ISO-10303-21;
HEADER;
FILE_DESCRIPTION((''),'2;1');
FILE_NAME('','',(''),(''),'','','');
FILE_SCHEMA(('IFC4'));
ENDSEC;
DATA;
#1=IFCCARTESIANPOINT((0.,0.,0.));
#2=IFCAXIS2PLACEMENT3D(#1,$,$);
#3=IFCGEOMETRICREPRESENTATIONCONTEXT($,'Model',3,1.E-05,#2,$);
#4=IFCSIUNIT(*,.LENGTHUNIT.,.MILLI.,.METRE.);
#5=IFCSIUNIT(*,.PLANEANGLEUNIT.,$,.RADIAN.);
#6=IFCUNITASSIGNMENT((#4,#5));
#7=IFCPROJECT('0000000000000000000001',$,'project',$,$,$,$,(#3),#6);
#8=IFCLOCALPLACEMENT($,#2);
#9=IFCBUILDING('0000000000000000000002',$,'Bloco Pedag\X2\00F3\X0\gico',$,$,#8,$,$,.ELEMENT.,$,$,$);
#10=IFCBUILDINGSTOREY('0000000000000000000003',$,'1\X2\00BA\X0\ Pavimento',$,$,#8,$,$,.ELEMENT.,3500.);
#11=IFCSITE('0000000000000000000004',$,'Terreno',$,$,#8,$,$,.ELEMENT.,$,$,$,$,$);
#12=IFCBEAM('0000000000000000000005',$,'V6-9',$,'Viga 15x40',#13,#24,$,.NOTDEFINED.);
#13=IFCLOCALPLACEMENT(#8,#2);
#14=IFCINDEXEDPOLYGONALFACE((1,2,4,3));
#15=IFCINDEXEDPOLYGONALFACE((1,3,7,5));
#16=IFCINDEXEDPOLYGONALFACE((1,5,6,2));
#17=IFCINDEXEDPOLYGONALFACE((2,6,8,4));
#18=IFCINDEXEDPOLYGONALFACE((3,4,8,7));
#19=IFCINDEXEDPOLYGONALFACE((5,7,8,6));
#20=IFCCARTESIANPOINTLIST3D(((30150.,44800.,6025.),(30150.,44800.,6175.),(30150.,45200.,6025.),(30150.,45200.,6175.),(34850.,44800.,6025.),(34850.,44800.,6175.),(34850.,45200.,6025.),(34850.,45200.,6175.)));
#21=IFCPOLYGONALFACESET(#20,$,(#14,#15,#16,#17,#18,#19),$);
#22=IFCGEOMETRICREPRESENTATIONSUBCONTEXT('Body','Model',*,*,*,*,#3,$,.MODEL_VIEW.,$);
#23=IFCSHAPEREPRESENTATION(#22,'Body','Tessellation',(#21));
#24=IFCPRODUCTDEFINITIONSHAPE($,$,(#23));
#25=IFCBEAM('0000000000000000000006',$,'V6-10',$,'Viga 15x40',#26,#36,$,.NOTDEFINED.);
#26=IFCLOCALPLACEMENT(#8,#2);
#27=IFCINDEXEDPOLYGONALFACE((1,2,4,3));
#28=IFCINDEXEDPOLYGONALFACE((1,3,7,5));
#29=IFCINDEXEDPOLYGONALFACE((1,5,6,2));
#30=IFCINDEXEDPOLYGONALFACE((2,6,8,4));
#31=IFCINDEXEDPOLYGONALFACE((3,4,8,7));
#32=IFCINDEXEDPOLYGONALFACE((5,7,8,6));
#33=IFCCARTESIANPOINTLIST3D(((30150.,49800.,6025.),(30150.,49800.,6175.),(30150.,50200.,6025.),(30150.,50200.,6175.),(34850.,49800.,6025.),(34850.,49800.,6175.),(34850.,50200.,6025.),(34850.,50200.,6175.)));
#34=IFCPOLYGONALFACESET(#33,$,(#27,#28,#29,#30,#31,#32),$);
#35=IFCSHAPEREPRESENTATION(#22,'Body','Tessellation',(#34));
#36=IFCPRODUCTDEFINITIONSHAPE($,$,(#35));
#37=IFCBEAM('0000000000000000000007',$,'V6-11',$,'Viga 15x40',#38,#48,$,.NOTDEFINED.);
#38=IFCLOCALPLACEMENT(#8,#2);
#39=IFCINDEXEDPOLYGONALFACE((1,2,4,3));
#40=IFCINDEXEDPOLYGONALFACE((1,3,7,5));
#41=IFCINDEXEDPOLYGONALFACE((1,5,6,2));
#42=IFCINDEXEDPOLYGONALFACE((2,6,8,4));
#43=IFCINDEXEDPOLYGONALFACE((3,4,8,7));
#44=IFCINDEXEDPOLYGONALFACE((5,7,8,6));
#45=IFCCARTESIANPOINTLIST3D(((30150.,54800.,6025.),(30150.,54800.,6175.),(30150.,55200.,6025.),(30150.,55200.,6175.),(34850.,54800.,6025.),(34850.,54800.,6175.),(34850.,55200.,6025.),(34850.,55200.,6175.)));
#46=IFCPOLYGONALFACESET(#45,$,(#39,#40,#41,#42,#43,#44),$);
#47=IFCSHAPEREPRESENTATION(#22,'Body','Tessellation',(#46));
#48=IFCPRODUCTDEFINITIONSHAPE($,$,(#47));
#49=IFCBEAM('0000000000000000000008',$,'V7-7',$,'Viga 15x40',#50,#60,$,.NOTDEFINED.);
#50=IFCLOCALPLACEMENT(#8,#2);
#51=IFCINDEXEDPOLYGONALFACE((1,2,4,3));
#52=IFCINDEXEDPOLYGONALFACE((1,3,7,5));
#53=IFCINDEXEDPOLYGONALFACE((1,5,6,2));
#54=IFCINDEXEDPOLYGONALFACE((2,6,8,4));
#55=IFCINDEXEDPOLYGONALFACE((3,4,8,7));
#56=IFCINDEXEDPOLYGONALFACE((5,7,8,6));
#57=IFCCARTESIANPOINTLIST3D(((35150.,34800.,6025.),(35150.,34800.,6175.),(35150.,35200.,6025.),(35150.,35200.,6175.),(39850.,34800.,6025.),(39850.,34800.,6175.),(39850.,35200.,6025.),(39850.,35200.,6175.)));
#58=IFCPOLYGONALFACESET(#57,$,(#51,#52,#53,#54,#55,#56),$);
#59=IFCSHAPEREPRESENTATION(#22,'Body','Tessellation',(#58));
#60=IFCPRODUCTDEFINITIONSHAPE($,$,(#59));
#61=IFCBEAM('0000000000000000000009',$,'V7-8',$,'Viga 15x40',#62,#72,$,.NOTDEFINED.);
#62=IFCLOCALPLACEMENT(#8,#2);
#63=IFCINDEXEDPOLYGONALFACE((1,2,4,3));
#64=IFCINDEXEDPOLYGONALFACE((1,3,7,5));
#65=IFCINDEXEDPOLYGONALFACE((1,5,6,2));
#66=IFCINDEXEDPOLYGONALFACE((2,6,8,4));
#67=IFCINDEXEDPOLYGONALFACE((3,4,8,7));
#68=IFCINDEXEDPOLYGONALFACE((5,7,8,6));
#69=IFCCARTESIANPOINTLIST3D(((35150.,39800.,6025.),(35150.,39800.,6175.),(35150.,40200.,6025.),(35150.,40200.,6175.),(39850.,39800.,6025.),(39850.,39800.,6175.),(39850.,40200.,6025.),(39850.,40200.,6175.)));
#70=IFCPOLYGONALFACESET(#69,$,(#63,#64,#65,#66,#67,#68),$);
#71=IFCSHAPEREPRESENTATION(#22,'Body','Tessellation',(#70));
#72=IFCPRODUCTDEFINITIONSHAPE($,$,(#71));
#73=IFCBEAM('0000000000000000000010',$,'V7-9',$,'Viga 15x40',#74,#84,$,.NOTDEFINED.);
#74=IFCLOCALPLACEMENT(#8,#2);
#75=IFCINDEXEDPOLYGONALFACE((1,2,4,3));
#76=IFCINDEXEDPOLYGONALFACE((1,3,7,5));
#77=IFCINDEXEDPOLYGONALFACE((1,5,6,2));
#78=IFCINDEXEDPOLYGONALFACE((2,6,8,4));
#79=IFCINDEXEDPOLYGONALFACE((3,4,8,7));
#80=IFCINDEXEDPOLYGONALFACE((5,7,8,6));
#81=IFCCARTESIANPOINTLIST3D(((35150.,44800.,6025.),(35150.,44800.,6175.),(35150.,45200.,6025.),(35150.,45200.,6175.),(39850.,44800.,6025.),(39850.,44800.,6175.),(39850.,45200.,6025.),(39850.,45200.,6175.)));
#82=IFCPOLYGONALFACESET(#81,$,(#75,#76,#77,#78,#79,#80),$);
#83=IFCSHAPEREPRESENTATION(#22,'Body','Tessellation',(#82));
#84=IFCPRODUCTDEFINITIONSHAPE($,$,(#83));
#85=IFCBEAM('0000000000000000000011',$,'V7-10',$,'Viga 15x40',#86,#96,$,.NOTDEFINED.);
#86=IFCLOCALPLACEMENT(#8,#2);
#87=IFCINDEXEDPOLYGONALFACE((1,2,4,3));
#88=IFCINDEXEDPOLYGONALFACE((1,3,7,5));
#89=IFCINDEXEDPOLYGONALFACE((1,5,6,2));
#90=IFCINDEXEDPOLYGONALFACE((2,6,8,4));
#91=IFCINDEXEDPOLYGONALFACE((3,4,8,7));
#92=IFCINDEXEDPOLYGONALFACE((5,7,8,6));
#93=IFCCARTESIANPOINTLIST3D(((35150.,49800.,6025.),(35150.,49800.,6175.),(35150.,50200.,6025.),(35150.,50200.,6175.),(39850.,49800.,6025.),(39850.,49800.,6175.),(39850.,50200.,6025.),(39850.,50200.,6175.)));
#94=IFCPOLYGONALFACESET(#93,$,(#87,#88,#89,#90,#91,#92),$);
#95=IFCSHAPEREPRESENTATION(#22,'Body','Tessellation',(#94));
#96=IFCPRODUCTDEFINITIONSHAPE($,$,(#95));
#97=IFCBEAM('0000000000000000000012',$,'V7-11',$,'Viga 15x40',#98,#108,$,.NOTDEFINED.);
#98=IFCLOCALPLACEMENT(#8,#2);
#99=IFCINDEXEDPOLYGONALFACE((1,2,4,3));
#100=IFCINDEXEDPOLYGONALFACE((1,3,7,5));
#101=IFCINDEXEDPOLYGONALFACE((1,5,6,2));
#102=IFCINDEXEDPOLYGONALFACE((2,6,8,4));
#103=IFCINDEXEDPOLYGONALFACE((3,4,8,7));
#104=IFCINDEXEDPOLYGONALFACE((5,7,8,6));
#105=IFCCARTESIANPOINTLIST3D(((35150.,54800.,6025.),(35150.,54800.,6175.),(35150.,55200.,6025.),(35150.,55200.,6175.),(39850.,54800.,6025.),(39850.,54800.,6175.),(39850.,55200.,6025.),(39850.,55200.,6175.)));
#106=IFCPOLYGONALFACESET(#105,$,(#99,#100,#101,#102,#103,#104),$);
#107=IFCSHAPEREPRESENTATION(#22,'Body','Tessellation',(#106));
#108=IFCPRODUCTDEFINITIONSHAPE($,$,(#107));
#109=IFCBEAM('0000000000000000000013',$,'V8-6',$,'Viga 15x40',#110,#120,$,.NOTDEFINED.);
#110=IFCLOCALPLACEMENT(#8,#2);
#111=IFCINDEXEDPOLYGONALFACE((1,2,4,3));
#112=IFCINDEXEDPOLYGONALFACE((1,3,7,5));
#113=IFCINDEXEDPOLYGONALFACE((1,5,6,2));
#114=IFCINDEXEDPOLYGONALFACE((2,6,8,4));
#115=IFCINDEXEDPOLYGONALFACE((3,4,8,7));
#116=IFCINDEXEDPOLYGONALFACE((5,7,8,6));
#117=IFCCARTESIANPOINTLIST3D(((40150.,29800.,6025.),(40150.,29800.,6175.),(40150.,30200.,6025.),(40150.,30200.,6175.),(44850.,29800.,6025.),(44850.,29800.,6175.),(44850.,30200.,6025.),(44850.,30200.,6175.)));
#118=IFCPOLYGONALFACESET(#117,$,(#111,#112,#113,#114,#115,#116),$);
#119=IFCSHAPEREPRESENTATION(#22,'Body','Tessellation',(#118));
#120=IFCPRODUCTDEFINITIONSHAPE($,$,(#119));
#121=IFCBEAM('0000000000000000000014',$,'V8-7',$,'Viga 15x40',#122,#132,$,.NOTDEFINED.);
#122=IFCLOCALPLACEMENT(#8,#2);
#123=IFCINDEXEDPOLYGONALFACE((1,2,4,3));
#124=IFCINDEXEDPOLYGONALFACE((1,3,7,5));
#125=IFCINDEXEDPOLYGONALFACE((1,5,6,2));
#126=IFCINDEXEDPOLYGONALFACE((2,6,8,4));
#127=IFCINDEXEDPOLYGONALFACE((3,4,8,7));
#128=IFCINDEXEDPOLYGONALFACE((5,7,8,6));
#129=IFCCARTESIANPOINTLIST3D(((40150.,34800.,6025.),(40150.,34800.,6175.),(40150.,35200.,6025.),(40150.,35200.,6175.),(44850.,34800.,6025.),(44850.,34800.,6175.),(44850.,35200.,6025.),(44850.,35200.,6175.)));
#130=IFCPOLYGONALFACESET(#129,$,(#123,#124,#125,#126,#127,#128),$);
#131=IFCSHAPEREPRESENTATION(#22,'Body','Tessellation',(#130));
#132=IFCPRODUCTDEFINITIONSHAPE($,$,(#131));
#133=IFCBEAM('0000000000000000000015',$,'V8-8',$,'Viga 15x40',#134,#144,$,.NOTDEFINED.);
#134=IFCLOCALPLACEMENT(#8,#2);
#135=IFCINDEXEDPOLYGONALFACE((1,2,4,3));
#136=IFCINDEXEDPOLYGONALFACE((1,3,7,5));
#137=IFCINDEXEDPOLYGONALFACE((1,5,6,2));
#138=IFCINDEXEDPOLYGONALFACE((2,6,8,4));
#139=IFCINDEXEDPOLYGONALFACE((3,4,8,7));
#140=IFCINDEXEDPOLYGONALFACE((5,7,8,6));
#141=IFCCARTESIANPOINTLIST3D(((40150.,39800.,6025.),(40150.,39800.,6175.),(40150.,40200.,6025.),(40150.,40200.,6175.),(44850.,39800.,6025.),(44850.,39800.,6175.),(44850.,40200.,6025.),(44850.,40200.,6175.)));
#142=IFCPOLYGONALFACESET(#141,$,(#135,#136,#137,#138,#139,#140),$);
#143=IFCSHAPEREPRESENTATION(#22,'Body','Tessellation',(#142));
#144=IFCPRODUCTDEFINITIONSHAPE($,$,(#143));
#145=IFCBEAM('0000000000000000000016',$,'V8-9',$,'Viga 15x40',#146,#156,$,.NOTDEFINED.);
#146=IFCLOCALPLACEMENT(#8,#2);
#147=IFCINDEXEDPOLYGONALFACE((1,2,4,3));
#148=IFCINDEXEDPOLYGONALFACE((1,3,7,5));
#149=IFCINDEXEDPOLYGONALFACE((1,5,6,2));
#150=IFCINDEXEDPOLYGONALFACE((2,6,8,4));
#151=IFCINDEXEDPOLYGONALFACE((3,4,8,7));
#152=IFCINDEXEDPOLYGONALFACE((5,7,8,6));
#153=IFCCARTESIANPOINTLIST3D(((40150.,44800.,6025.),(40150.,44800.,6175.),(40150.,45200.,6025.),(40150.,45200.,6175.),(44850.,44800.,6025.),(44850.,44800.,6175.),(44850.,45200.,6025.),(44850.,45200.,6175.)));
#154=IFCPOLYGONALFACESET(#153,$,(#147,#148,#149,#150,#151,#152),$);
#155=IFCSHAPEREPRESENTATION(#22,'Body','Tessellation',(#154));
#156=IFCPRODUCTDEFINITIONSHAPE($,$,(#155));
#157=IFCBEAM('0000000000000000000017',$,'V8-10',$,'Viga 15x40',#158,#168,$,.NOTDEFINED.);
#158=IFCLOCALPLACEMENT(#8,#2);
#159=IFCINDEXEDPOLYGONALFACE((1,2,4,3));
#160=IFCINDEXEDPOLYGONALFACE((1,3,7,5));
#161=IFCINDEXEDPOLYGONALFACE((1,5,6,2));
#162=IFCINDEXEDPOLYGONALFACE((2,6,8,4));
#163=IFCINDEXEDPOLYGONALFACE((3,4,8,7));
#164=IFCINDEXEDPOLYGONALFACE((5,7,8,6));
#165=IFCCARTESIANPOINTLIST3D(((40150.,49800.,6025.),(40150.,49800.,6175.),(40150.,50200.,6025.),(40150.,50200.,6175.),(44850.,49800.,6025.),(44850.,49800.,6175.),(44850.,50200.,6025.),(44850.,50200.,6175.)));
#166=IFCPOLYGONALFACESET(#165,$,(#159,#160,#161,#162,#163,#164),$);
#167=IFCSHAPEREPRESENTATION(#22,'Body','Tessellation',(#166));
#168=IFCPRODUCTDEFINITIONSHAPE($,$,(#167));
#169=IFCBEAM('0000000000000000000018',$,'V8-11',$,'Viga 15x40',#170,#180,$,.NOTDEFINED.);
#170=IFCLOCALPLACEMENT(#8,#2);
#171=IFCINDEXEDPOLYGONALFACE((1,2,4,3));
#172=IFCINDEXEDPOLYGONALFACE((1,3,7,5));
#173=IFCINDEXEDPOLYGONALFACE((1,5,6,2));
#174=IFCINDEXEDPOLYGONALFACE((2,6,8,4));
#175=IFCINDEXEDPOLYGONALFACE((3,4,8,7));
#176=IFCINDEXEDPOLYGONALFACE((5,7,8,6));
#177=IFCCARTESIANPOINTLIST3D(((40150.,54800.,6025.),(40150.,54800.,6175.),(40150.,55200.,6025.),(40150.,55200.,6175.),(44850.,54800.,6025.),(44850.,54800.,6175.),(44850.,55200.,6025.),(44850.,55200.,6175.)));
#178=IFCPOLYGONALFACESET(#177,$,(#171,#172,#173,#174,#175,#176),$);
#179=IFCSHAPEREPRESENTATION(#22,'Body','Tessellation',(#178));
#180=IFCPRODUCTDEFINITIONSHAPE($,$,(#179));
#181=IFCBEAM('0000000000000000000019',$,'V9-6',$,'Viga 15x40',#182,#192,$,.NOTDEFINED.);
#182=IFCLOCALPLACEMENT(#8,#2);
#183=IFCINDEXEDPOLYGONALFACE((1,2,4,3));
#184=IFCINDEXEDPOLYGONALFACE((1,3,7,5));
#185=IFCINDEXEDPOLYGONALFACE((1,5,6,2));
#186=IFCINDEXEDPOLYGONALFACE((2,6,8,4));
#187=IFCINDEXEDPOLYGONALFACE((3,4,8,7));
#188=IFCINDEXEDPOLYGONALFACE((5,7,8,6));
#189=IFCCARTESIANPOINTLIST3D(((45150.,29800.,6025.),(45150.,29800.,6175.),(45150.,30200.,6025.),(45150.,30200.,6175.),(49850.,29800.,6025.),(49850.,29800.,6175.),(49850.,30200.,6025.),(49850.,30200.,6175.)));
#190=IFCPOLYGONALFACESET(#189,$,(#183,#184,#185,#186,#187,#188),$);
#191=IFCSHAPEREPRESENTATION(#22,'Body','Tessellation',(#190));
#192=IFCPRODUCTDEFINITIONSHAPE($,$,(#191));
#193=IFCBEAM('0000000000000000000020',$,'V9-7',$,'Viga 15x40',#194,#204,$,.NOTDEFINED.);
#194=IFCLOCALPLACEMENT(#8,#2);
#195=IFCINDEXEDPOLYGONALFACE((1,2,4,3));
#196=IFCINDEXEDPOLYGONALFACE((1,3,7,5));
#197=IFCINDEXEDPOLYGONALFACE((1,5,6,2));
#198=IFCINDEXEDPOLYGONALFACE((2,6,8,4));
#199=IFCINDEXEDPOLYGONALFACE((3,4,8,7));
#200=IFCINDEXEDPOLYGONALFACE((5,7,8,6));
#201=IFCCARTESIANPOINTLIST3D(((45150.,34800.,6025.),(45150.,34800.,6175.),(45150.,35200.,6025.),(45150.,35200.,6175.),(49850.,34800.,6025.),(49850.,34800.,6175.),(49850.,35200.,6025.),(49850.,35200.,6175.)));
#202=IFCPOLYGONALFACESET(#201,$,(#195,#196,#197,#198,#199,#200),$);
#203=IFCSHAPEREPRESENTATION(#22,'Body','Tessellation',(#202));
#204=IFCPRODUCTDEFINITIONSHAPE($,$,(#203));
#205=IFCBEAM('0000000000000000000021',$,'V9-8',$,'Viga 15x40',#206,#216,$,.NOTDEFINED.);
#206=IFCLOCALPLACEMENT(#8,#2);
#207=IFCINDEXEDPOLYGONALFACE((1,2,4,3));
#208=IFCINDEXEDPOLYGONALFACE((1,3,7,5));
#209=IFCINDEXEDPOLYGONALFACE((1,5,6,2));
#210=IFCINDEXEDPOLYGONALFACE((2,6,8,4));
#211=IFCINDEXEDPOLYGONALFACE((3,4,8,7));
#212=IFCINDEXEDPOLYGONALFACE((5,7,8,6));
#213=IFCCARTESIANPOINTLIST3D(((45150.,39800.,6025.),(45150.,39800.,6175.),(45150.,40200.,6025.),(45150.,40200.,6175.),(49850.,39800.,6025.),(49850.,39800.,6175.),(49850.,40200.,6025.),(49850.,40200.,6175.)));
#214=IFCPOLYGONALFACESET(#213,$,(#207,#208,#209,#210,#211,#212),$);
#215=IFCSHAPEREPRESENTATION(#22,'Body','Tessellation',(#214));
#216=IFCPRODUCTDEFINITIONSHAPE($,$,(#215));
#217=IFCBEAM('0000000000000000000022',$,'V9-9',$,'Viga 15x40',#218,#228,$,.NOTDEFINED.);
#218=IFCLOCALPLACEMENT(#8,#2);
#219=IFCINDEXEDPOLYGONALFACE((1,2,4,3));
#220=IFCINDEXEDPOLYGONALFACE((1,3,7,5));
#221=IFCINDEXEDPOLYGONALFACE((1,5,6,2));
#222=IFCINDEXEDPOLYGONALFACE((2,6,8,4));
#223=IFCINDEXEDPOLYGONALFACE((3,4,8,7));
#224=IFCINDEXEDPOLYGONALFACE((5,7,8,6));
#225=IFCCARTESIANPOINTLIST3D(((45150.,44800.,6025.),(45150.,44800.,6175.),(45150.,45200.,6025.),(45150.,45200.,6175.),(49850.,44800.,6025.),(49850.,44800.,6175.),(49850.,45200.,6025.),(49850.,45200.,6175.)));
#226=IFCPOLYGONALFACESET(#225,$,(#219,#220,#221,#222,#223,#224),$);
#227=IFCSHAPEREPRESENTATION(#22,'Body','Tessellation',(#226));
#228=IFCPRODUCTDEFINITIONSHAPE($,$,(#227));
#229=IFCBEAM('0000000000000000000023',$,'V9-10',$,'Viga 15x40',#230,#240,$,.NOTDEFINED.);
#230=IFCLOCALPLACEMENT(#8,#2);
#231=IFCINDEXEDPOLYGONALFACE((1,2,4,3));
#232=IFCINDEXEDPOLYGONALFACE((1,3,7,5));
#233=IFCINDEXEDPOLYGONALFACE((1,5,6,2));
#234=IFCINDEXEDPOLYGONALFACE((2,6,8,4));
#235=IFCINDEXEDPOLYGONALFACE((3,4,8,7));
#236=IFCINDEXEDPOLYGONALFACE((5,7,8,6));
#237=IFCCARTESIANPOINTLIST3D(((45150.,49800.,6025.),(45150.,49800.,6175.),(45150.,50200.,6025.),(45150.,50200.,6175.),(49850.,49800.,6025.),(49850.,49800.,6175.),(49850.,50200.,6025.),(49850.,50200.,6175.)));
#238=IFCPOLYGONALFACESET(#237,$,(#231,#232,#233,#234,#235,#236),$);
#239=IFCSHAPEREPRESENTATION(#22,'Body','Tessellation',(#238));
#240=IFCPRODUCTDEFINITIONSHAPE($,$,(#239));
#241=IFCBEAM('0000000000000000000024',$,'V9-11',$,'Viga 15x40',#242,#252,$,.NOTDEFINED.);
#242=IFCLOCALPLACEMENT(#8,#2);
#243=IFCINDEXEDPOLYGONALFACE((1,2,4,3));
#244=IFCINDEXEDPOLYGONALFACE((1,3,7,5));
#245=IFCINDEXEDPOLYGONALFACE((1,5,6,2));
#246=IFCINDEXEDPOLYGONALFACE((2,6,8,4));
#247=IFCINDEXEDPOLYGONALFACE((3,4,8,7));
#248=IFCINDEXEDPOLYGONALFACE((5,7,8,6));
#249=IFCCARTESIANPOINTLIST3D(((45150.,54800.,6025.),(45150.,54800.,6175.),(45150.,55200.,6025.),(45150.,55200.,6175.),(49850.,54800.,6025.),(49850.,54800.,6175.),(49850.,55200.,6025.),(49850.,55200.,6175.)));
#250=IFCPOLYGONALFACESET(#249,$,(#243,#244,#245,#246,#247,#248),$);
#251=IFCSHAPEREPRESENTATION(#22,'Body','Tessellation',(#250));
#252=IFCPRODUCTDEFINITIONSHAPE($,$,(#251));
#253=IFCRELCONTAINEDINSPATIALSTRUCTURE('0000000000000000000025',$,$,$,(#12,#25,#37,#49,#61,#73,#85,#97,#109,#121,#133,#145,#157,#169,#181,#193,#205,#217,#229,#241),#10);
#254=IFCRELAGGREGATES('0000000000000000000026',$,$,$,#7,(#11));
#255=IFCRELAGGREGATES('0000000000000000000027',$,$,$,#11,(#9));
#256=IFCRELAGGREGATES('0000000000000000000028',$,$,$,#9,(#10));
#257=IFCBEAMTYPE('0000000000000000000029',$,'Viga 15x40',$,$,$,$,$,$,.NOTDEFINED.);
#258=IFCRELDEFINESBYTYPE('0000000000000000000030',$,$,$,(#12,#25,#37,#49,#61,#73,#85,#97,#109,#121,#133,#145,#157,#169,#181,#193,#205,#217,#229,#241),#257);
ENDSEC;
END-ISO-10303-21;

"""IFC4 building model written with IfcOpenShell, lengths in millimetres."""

from ifc_helpers import new_model, si_unit, frame, origin, origin_2d, place, context, subcontext, project, spatial, rectangle, extrude, type_object, element, save


model = new_model("IFC4")

# Units and contexts
model_context = context("Model", 3, precision=1e-05, world=origin())
body_context = subcontext(model_context, "Body", "Model", "MODEL_VIEW")
ifc_project = project(units=[si_unit("LENGTHUNIT", "METRE", prefix="MILLI"), si_unit("PLANEANGLEUNIT", "RADIAN")], contexts=[model_context])

# Site, building, storey
placement = place(None, origin())
site = spatial("IfcSite", under=ifc_project, at=placement, Name="Terreno", CompositionType="ELEMENT")
building = spatial("IfcBuilding", under=site, at=placement, Name="Bloco Pedagógico", CompositionType="ELEMENT")
storey = spatial("IfcBuildingStorey", under=building, at=placement, Name="1º Pavimento", CompositionType="ELEMENT", Elevation=3500.0)

# Beams
beam_type = type_object("IfcBeamType", Name="Viga 15x40", PredefinedType="NOTDEFINED")
for number, where, z_axis, x_axis, name in (
    (1, (30150.0, 45000.0, 6100.0), (1.0, 0.0, 0.0), (0.0, 1.0, 0.0), "V6-9"),
    (2, (30150.0, 50000.0, 6100.0), (1.0, 0.0, 0.0), (0.0, 1.0, 0.0), "V6-10"),
    (3, (30150.0, 55000.0, 6100.0), (1.0, 0.0, 0.0), (0.0, 1.0, 0.0), "V6-11"),
    (4, (35150.0, 35000.0, 6100.0), (1.0, 0.0, 0.0), (0.0, 1.0, 0.0), "V7-7"),
    (5, (35150.0, 40000.0, 6100.0), (1.0, 0.0, 0.0), (0.0, 1.0, 0.0), "V7-8"),
    (6, (35150.0, 45000.0, 6100.0), (1.0, 0.0, 0.0), (0.0, 1.0, 0.0), "V7-9"),
    (7, (35150.0, 50000.0, 6100.0), (1.0, 0.0, 0.0), (0.0, 1.0, 0.0), "V7-10"),
    (8, (35150.0, 55000.0, 6100.0), (1.0, 0.0, 0.0), (0.0, 1.0, 0.0), "V7-11"),
    (9, (40150.0, 30000.0, 6100.0), (1.0, 0.0, 0.0), (0.0, 1.0, 0.0), "V8-6"),
    (10, (40150.0, 35000.0, 6100.0), (1.0, 0.0, 0.0), (0.0, 1.0, 0.0), "V8-7"),
    (11, (40150.0, 40000.0, 6100.0), (1.0, 0.0, 0.0), (0.0, 1.0, 0.0), "V8-8"),
    (12, (40150.0, 45000.0, 6100.0), (1.0, 0.0, 0.0), (0.0, 1.0, 0.0), "V8-9"),
    (13, (40150.0, 50000.0, 6100.0), (1.0, 0.0, 0.0), (0.0, 1.0, 0.0), "V8-10"),
    (14, (40150.0, 55000.0, 6100.0), (1.0, 0.0, 0.0), (0.0, 1.0, 0.0), "V8-11"),
    (15, (45150.0, 30000.0, 6100.0), (1.0, 0.0, 0.0), (0.0, 1.0, 0.0), "V9-6"),
    (16, (45150.0, 35000.0, 6100.0), (1.0, 0.0, 0.0), (0.0, 1.0, 0.0), "V9-7"),
    (17, (45150.0, 40000.0, 6100.0), (1.0, 0.0, 0.0), (0.0, 1.0, 0.0), "V9-8"),
    (18, (45150.0, 45000.0, 6100.0), (1.0, 0.0, 0.0), (0.0, 1.0, 0.0), "V9-9"),
    (19, (45150.0, 50000.0, 6100.0), (1.0, 0.0, 0.0), (0.0, 1.0, 0.0), "V9-10"),
    (20, (45150.0, 55000.0, 6100.0), (1.0, 0.0, 0.0), (0.0, 1.0, 0.0), "V9-11"),
):
    element("IfcBeam", number, at=place(None, frame(where, z_axis=z_axis, x_axis=x_axis)), inside=storey, type_object=beam_type, Name=name, ObjectType="Viga 15x40", PredefinedType="NOTDEFINED", context=body_context, shape_type="SweptSolid", body=[
        extrude(rectangle(XDim=400.0, YDim=150.0, at=origin_2d()), None, (0.0, 0.0, 1.0), 4700.0),
    ])

save(model, "model.ifc")
